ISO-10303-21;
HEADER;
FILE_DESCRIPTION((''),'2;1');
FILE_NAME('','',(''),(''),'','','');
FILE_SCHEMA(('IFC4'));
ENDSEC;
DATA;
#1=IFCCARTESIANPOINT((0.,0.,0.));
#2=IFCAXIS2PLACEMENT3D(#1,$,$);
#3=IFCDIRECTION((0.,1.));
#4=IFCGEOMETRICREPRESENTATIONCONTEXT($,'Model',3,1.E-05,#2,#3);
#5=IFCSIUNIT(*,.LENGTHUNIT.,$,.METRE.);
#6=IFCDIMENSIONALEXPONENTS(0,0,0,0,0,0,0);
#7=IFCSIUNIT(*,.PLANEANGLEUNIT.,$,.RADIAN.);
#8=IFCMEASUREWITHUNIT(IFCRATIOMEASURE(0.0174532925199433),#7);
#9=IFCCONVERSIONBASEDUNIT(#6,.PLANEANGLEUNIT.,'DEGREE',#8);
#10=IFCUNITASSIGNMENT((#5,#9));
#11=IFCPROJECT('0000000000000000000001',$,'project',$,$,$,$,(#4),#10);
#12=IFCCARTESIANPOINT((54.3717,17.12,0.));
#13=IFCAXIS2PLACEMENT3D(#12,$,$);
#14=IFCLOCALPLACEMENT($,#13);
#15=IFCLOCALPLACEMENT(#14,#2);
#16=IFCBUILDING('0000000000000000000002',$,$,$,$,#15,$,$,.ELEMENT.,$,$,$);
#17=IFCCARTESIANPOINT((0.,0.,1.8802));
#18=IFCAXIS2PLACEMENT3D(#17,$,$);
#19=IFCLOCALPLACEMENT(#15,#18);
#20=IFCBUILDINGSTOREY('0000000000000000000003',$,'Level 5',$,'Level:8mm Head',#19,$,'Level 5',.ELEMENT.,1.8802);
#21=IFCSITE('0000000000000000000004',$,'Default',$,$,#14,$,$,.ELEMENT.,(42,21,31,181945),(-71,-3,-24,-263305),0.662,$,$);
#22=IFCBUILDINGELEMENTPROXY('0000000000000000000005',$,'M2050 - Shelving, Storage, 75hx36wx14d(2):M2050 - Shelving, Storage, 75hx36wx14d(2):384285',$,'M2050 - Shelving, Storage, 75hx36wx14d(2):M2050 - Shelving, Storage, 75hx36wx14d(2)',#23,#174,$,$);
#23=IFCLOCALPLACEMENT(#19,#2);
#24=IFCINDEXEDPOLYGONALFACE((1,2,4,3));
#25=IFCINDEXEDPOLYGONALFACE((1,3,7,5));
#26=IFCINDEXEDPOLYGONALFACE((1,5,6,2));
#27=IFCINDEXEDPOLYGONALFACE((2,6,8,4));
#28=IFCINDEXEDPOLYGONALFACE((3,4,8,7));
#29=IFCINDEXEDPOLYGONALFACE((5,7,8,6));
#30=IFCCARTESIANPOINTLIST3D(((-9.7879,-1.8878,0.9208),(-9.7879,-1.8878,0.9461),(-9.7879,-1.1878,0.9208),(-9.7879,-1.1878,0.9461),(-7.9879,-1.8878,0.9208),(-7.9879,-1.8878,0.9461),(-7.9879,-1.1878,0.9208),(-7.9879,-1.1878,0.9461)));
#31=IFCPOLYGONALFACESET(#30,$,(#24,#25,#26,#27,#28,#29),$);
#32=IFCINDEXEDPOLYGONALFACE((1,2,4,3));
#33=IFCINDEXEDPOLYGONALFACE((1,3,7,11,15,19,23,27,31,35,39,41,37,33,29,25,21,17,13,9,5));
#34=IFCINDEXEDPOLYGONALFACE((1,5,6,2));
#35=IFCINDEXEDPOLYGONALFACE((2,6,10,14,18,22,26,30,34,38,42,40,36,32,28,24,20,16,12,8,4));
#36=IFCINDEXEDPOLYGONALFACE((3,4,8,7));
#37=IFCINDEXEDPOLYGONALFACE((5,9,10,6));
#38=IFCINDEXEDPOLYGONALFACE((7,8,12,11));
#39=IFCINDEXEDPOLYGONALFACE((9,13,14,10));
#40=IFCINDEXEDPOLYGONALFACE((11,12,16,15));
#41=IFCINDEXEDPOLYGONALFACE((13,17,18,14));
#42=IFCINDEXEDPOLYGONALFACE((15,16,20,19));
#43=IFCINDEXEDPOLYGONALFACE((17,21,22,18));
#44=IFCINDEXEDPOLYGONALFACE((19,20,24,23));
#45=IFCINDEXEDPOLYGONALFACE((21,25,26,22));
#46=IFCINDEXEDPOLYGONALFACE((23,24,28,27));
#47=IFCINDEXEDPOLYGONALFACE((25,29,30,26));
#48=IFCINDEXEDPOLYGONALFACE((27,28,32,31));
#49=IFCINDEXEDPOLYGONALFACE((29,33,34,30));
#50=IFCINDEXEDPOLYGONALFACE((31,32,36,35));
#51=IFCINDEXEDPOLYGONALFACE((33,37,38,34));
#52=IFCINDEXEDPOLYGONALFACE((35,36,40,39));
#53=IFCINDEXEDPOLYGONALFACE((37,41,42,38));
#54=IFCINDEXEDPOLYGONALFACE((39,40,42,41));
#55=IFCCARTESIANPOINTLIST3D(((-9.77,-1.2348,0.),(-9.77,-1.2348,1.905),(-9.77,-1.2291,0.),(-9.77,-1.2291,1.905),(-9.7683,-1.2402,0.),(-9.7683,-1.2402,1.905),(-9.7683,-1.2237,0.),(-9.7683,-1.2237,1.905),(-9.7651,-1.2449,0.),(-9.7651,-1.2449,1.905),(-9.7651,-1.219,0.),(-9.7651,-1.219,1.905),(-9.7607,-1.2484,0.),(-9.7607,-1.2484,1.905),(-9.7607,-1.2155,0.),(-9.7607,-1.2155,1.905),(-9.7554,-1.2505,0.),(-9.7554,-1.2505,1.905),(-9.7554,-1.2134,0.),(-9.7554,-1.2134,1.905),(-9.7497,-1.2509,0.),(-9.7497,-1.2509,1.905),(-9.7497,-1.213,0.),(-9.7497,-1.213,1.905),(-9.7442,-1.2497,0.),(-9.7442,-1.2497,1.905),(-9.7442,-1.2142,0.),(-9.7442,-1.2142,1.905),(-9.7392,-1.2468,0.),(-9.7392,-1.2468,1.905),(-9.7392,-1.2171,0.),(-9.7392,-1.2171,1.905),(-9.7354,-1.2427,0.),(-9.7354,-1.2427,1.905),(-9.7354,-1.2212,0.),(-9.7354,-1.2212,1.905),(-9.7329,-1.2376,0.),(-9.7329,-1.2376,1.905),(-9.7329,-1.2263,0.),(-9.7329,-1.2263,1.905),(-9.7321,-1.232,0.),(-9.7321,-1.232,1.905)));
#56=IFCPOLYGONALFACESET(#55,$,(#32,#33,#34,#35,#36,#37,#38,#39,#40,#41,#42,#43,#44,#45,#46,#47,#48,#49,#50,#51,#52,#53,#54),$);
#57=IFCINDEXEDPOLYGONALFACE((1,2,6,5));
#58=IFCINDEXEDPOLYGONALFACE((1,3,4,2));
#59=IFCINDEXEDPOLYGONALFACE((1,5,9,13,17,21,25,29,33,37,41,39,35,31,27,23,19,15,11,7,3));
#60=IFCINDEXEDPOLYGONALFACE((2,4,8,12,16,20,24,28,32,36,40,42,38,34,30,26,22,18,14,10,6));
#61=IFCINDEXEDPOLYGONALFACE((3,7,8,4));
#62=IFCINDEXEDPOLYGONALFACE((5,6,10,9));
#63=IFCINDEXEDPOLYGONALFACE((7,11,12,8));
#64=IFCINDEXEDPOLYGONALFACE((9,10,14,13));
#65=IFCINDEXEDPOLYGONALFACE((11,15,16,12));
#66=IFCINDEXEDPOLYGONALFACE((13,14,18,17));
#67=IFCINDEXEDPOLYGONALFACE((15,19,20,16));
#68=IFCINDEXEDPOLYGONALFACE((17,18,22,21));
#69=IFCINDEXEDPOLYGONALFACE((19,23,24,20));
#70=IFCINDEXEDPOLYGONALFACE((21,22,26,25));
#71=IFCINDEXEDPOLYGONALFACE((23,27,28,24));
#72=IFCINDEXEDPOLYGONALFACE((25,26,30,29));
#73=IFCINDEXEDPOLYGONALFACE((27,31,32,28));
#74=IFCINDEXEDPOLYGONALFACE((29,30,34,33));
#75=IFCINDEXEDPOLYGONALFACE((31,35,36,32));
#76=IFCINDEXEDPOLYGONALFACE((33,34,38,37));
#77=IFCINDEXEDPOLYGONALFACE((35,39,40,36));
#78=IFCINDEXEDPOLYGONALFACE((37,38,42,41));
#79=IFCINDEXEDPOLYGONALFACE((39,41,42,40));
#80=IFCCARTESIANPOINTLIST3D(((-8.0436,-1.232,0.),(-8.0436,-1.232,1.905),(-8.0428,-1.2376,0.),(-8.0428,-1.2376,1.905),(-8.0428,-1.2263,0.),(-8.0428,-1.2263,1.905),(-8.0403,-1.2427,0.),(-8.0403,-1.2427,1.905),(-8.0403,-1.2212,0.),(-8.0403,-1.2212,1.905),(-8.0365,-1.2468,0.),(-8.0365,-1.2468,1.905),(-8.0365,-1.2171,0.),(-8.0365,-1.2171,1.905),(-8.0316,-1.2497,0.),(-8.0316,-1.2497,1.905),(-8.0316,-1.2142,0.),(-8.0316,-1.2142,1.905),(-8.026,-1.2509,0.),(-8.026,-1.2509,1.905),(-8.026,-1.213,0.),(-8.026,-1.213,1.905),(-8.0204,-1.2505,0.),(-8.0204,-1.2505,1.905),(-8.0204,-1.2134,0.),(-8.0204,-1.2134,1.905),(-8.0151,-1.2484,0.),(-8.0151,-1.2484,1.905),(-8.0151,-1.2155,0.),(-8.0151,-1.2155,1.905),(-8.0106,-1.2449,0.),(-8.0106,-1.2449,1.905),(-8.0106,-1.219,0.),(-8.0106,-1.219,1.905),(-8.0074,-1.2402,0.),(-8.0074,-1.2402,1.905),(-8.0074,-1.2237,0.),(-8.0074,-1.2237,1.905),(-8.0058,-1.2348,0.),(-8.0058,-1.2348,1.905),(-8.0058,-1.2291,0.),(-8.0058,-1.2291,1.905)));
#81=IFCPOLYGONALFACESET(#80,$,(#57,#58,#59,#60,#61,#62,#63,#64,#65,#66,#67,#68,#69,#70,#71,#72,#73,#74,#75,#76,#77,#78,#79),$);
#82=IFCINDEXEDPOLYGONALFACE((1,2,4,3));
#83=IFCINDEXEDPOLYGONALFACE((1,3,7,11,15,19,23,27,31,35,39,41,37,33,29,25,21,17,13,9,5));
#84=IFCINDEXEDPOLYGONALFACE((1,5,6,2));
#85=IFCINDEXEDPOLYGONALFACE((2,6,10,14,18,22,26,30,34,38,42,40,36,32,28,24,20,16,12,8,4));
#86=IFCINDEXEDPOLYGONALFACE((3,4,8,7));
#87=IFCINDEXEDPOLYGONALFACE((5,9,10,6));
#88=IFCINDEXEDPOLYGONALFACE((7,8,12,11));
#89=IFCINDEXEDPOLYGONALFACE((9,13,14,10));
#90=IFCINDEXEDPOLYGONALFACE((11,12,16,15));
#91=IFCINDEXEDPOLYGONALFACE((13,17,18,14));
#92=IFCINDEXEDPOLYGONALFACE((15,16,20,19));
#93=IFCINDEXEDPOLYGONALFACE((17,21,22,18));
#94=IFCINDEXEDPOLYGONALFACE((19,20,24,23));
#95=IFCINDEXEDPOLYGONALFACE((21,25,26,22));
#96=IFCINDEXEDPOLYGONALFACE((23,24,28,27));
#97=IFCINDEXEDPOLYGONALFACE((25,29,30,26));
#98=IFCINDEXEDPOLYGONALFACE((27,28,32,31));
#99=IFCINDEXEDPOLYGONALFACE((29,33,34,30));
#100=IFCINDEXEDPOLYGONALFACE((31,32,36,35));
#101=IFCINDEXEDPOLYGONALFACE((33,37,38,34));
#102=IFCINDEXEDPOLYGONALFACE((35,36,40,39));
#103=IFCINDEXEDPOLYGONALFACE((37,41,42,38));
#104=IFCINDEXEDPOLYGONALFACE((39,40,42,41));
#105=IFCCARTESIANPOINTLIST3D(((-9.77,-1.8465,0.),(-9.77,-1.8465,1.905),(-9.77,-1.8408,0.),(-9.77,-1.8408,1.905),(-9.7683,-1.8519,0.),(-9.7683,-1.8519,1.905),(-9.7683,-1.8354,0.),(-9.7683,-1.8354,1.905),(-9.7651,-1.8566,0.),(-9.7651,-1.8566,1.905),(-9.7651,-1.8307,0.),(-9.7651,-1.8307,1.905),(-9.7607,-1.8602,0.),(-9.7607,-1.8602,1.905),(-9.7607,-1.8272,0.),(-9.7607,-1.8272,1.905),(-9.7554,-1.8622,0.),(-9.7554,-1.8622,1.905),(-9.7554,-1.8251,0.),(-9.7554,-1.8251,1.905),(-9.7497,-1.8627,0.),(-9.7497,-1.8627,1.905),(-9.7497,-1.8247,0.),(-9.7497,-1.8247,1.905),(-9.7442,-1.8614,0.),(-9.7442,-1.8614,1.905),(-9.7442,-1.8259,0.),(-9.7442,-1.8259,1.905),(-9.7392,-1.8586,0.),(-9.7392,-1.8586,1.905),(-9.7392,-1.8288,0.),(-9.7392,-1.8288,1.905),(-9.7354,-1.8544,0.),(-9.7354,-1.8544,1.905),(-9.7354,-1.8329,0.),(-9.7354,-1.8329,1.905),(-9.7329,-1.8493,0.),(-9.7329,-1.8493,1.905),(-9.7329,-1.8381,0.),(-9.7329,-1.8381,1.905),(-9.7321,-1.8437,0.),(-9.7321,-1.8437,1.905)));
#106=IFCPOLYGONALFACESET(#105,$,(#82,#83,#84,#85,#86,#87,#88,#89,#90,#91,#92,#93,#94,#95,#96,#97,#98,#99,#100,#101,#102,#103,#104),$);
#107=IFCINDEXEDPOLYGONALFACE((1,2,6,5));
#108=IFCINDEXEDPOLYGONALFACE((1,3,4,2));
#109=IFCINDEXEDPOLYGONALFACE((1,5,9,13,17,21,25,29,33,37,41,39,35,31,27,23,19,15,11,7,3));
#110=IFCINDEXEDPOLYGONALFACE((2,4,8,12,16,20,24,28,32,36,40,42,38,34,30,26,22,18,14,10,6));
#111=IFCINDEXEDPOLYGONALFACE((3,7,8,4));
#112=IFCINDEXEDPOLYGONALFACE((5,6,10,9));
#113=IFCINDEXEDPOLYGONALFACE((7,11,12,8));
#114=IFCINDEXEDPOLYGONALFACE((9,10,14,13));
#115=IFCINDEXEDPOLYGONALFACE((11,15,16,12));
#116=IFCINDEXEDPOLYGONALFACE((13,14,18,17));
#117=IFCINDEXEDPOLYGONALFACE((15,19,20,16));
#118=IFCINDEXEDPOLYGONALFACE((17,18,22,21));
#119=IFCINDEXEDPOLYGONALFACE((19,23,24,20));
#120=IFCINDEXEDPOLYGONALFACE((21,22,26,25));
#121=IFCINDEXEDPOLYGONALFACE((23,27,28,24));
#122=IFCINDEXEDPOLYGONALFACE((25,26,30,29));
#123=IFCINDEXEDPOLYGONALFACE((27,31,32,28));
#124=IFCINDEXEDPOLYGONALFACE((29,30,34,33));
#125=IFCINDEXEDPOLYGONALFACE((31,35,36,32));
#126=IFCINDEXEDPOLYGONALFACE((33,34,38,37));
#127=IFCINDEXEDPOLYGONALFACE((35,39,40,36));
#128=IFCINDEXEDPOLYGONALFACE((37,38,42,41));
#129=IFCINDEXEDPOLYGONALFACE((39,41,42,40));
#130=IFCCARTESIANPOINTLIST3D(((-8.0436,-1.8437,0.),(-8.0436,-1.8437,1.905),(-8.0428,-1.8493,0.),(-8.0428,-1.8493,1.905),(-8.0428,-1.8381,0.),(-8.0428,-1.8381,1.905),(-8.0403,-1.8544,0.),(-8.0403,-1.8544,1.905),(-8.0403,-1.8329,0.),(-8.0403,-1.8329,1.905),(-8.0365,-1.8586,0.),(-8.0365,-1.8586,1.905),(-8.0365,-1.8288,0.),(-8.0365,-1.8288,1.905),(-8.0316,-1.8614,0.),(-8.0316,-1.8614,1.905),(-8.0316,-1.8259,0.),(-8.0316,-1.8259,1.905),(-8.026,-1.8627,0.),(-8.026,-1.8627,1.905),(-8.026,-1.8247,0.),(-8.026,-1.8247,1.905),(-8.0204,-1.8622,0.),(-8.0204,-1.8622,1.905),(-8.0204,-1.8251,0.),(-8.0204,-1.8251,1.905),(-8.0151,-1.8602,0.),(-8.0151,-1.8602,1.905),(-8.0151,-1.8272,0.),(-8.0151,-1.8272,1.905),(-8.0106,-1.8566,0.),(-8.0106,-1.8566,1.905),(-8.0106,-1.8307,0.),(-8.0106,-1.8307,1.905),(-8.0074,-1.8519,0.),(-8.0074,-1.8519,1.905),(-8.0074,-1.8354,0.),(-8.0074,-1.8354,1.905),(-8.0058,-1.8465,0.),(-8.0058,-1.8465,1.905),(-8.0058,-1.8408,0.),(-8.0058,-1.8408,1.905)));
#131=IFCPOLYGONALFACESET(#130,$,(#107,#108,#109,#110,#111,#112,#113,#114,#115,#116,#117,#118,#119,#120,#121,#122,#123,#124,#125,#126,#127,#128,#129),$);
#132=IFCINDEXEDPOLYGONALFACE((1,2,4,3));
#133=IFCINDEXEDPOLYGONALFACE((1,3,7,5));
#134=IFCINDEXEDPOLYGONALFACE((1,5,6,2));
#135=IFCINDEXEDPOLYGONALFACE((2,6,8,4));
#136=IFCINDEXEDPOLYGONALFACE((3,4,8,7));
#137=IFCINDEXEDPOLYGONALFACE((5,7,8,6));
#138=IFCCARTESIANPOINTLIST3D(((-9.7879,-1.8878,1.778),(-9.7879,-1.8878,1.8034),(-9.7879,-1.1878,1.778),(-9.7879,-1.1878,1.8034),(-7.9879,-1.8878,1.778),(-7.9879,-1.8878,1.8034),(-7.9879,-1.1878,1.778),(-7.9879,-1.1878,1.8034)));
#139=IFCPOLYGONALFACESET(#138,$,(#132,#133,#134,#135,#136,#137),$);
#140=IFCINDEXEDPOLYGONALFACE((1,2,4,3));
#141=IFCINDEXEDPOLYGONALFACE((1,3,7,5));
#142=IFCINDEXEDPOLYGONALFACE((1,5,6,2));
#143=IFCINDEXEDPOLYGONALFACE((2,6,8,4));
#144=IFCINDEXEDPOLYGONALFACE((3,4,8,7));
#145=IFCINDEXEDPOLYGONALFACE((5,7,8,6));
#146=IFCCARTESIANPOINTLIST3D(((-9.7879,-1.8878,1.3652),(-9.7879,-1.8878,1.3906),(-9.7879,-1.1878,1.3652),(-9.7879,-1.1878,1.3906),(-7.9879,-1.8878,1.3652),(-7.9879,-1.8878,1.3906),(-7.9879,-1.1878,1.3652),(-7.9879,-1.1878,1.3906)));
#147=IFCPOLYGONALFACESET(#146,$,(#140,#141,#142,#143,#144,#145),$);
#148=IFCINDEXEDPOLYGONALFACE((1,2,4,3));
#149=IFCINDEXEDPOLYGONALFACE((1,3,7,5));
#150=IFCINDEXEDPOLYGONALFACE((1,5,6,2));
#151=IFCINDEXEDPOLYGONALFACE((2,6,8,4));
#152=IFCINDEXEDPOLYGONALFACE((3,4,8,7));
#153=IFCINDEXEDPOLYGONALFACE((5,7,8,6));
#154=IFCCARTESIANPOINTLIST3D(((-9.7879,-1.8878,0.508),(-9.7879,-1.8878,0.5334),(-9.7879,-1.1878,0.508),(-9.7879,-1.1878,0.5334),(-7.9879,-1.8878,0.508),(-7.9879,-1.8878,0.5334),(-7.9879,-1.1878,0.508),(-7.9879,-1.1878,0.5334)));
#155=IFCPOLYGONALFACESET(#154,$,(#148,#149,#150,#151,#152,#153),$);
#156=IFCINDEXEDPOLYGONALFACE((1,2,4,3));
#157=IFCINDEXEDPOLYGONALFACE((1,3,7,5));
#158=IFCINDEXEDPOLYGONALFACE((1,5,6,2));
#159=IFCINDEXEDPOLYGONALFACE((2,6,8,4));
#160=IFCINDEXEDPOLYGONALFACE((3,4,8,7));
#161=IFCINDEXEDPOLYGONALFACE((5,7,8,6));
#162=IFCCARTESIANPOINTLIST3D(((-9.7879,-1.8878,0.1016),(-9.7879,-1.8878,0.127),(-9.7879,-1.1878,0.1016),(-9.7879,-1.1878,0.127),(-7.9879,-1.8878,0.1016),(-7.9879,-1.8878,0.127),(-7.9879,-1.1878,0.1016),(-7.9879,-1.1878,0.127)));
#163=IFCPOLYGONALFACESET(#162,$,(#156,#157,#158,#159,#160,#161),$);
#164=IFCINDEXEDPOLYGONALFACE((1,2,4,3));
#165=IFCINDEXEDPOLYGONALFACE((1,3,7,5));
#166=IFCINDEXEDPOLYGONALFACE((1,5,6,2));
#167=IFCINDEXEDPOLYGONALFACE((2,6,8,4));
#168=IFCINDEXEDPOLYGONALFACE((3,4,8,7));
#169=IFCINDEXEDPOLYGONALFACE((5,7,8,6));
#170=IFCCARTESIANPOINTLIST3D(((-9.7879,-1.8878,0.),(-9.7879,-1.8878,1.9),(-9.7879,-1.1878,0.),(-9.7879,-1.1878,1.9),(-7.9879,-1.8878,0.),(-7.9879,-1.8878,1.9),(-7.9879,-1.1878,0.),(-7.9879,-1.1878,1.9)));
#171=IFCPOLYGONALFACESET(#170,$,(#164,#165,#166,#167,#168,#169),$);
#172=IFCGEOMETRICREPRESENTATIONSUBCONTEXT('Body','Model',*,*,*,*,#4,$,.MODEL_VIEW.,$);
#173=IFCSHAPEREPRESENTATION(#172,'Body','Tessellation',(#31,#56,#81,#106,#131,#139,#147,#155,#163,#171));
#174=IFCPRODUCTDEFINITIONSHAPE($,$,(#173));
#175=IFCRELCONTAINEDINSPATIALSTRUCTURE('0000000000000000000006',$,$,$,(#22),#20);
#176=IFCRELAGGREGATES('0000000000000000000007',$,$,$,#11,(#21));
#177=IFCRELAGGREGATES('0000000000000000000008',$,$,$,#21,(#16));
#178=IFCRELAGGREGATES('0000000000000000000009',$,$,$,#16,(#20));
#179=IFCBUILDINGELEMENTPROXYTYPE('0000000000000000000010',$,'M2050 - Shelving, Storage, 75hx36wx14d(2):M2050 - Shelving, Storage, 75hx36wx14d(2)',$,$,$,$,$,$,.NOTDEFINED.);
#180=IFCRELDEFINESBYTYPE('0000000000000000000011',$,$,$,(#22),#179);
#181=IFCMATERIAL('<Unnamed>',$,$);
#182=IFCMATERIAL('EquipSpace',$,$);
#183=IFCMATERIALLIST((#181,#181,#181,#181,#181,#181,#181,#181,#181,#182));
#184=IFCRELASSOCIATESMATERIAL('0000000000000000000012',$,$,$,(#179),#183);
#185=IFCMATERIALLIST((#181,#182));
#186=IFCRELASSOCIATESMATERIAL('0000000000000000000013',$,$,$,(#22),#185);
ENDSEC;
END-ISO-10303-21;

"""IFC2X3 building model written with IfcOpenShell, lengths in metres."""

from ifc_helpers import new_model, entity, si_unit, converted_unit, direction, frame, frame_2d, origin, origin_2d_with_axis, place, context, subcontext, project, spatial, rectangle, circle, extrude, source, transform, mapped, material, material_list, type_object, type_shapes, element, save


model = new_model("IFC2X3")

# Units and contexts
model_context = context("Model", 3, precision=1e-05, world=origin(), true_north=direction((0.0, 1.0)))
body_context = subcontext(model_context, "Body", "Model", "MODEL_VIEW")
ifc_project = project(units=[si_unit("LENGTHUNIT", "METRE"), converted_unit("PLANEANGLEUNIT", "DEGREE", entity("IfcRatioMeasure", 0.0174532925199433), si_unit("PLANEANGLEUNIT", "RADIAN"), dimensions=[0, 0, 0, 0, 0, 0, 0])], contexts=[model_context])

# Site, building, storey
site_placement = place(None, frame((54.3717, 17.12, 0.0)))
site = spatial("IfcSite", under=ifc_project, at=site_placement, Name="Default", CompositionType="ELEMENT", RefLatitude=(42, 21, 31, 181945), RefLongitude=(-71, -3, -24, -263305), RefElevation=0.662)
building_placement = place(site_placement, origin())
building = spatial("IfcBuilding", under=site, at=building_placement, CompositionType="ELEMENT")
storey_placement = place(building_placement, frame((0.0, 0.0, 1.8802)))
storey = spatial("IfcBuildingStorey", under=building, at=storey_placement, Name="Level 5", ObjectType="Level:8mm Head", LongName="Level 5", CompositionType="ELEMENT", Elevation=1.8802)

# Building element proxy
ifc_material_1 = material(Name="<Unnamed>")
ifc_material_2 = material(Name="EquipSpace")
ifc_material_list_1 = material_list([ifc_material_1, ifc_material_1, ifc_material_1, ifc_material_1, ifc_material_1, ifc_material_1, ifc_material_1, ifc_material_1, ifc_material_1, ifc_material_2])
building_element_proxy_type = type_object("IfcBuildingElementProxyType", Name="M2050 - Shelving, Storage, 75hx36wx14d(2):M2050 - Shelving, Storage, 75hx36wx14d(2)", PredefinedType="NOTDEFINED", material=ifc_material_list_1)
shared_shape = source(origin(), body_context, "Body", "SweptSolid", [
    extrude(rectangle(XDim=1.8, YDim=0.7, at=origin_2d_with_axis()), frame((0.0, 0.0, 0.9207), z_axis=(0.0, 0.0, 1.0), x_axis=(-1.0, 0.0, 0.0)), (0.0, 0.0, 1.0), 0.0254),
    extrude(circle(Radius=0.0191, at=origin_2d_with_axis()), frame((0.8633, -0.3059, 0.0), z_axis=(0.0, 0.0, 1.0), x_axis=(-1.0, 0.0, 0.0)), (0.0, 0.0, 1.0), 1.905),
    extrude(circle(Radius=0.0191, at=origin_2d_with_axis()), frame((-0.8633, -0.3059, 0.0)), (0.0, 0.0, 1.0), 1.905),
    extrude(circle(Radius=0.0191, at=origin_2d_with_axis()), frame((0.8633, 0.3059, 0.0), z_axis=(0.0, 0.0, 1.0), x_axis=(-1.0, 0.0, 0.0)), (0.0, 0.0, 1.0), 1.905),
    extrude(circle(Radius=0.0191, at=origin_2d_with_axis()), frame((-0.8633, 0.3059, 0.0)), (0.0, 0.0, 1.0), 1.905),
    extrude(rectangle(XDim=1.8, YDim=0.7, at=origin_2d_with_axis()), frame((0.0, 0.0, 1.778), z_axis=(0.0, 0.0, 1.0), x_axis=(-1.0, 0.0, 0.0)), (0.0, 0.0, 1.0), 0.0254),
    extrude(rectangle(XDim=1.8, YDim=0.7, at=origin_2d_with_axis()), frame((0.0, 0.0, 1.3653), z_axis=(0.0, 0.0, 1.0), x_axis=(-1.0, 0.0, 0.0)), (0.0, 0.0, 1.0), 0.0254),
    extrude(rectangle(XDim=1.8, YDim=0.7, at=origin_2d_with_axis()), frame((0.0, 0.0, 0.508), z_axis=(0.0, 0.0, 1.0), x_axis=(-1.0, 0.0, 0.0)), (0.0, 0.0, 1.0), 0.0254),
    extrude(rectangle(XDim=1.8, YDim=0.7, at=origin_2d_with_axis()), frame((0.0, 0.0, 0.1016), z_axis=(0.0, 0.0, 1.0), x_axis=(-1.0, 0.0, 0.0)), (0.0, 0.0, 1.0), 0.0254),
    extrude(rectangle(XDim=0.7, YDim=1.8, at=frame_2d((0.0, 0.18), x_axis=(1.0, 0.0))), frame((-0.18, 0.0, 0.0), z_axis=(0.0, 0.0, 1.0), x_axis=(0.0, -1.0, 0.0)), (0.0, 0.0, 1.0), 1.9),
])
type_shapes(building_element_proxy_type, [shared_shape])
ifc_material_list_2 = material_list([ifc_material_1, ifc_material_2])
proxy_1_placement = place(storey_placement, frame((-8.8879, -1.5378, 0.0), z_axis=(0.0, 0.0, 1.0), x_axis=(-1.0, 0.0, 0.0)))
element("IfcBuildingElementProxy", 1, at=proxy_1_placement, inside=storey, type_object=building_element_proxy_type, material=ifc_material_list_2, Name="M2050 - Shelving, Storage, 75hx36wx14d(2):M2050 - Shelving, Storage, 75hx36wx14d(2):384285", ObjectType="M2050 - Shelving, Storage, 75hx36wx14d(2):M2050 - Shelving, Storage, 75hx36wx14d(2)", context=body_context, shape_type="MappedRepresentation", body=[
    mapped(shared_shape, transform((0.0, 0.0, 0.0), scale=1.0)),
])

save(model, "model.ifc")
